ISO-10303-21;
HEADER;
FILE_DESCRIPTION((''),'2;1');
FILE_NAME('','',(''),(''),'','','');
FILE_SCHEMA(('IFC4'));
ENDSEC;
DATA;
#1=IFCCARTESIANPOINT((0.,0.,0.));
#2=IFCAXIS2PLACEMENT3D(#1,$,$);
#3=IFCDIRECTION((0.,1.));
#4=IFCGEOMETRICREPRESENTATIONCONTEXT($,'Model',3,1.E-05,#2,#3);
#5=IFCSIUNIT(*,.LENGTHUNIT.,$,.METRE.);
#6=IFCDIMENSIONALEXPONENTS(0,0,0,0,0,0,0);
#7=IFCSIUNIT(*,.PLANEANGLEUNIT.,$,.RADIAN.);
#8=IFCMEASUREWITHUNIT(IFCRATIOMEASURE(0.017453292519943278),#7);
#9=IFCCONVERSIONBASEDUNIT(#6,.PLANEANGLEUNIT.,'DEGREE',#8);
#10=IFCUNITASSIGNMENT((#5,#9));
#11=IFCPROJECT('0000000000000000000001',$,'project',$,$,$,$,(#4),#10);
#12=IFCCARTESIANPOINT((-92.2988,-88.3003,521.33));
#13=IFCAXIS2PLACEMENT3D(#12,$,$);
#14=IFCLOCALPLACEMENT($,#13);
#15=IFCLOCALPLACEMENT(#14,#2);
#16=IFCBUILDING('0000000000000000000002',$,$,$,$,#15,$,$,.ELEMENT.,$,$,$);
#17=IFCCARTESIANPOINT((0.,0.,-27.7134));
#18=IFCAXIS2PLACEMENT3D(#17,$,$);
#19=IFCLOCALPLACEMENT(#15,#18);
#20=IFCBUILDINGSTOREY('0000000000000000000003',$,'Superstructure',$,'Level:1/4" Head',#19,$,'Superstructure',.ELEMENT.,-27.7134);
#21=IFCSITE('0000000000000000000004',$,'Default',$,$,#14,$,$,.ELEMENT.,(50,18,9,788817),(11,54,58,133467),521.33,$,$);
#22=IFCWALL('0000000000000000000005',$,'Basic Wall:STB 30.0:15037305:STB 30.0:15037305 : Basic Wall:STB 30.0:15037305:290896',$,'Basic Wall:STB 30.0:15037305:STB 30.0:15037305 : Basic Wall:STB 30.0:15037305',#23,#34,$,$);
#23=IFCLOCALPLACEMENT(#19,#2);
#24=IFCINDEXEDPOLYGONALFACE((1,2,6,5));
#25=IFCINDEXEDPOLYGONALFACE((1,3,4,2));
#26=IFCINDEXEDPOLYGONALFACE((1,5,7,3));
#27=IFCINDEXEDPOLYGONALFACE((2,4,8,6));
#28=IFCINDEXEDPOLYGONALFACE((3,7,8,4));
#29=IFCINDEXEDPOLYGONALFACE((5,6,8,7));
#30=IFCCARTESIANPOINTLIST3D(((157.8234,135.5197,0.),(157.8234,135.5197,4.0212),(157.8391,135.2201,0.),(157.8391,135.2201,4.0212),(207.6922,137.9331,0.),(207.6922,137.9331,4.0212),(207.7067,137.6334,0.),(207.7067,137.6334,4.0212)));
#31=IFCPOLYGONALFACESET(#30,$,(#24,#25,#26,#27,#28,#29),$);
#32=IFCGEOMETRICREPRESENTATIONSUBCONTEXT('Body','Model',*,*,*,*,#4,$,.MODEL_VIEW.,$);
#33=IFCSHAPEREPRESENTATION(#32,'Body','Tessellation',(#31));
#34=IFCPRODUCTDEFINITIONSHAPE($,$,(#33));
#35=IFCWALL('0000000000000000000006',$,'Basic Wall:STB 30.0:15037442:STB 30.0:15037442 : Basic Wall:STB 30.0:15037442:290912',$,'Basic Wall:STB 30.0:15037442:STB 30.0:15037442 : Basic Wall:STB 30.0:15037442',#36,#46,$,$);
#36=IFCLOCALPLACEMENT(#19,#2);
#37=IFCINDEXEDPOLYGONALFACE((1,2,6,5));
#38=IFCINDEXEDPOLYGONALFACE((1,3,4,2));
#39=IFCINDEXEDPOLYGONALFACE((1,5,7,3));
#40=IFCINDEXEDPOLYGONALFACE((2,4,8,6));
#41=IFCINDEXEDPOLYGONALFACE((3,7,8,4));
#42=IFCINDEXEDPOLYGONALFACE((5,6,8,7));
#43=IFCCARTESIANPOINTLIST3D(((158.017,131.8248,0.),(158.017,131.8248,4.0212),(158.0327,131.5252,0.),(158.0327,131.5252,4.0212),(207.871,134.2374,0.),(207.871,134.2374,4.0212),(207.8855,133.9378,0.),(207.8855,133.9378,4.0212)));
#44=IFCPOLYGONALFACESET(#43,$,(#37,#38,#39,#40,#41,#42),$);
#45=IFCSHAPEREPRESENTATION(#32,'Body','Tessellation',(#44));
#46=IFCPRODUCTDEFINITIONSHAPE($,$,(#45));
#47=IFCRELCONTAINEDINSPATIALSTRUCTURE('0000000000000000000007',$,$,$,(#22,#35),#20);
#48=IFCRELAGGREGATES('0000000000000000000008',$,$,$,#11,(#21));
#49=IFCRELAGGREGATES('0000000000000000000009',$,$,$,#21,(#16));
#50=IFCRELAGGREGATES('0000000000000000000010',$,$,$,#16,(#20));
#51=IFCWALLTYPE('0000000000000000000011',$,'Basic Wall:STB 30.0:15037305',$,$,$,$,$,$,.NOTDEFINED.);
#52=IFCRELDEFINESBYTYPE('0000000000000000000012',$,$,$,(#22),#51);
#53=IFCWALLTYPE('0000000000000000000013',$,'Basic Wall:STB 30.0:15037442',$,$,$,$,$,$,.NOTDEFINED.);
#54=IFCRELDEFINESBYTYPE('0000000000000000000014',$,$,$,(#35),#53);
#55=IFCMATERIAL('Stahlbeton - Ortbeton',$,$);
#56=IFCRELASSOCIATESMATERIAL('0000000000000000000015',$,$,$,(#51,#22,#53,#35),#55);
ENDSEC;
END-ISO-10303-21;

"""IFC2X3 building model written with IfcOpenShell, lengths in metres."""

from ifc_helpers import new_model, entity, si_unit, converted_unit, direction, frame, origin, place, context, subcontext, project, spatial, polyline, outline, extrude, material, type_object, element, save


model = new_model("IFC2X3")

# Units and contexts
model_context = context("Model", 3, precision=1e-05, world=origin(), true_north=direction((0.0, 1.0)))
body_context = subcontext(model_context, "Body", "Model", "MODEL_VIEW")
ifc_project = project(units=[si_unit("LENGTHUNIT", "METRE"), converted_unit("PLANEANGLEUNIT", "DEGREE", entity("IfcRatioMeasure", 0.017453292519943278), si_unit("PLANEANGLEUNIT", "RADIAN"), dimensions=[0, 0, 0, 0, 0, 0, 0])], contexts=[model_context])

# Site, building, storey
site_placement = place(None, frame((-92.2988, -88.3003, 521.33)))
site = spatial("IfcSite", under=ifc_project, at=site_placement, Name="Default", CompositionType="ELEMENT", RefLatitude=(50, 18, 9, 788817), RefLongitude=(11, 54, 58, 133467), RefElevation=521.33)
building_placement = place(site_placement, origin())
building = spatial("IfcBuilding", under=site, at=building_placement, CompositionType="ELEMENT")
storey_placement = place(building_placement, frame((0.0, 0.0, -27.7134)))
storey = spatial("IfcBuildingStorey", under=building, at=storey_placement, Name="Superstructure", ObjectType="Level:1/4\" Head", LongName="Superstructure", CompositionType="ELEMENT", Elevation=-27.7134)

# Walls
ifc_material_1 = material(Name="Stahlbeton - Ortbeton")
wall_type_1 = type_object("IfcWallType", Name="Basic Wall:STB 30.0:15037305", PredefinedType="NOTDEFINED", material=ifc_material_1)
wall_1_placement = place(storey_placement, frame((157.8234, 135.2201, 0.0)))
element("IfcWall", 1, at=wall_1_placement, inside=storey, type_object=wall_type_1, material=ifc_material_1, Name="Basic Wall:STB 30.0:15037305:STB 30.0:15037305 : Basic Wall:STB 30.0:15037305:290896", ObjectType="Basic Wall:STB 30.0:15037305:STB 30.0:15037305 : Basic Wall:STB 30.0:15037305", context=body_context, shape_type="SweptSolid", body=[
    extrude(outline(polyline([(-24.9633, -0.15), (24.9639, -0.15), (24.9627, 0.15), (-24.9633, 0.15), (-24.9633, -0.15)])), frame((24.942, 1.3565, 0.0), z_axis=(0.0, 0.0, 1.0), x_axis=(-0.998831, -0.048337, 0.0)), (0.0, 0.0, 1.0), 4.0212),
])
wall_type_2 = type_object("IfcWallType", Name="Basic Wall:STB 30.0:15037442", PredefinedType="NOTDEFINED", material=ifc_material_1)
wall_2_placement = place(storey_placement, frame((158.017, 131.5252, 0.0)))
element("IfcWall", 2, at=wall_2_placement, inside=storey, type_object=wall_type_2, material=ifc_material_1, Name="Basic Wall:STB 30.0:15037442:STB 30.0:15037442 : Basic Wall:STB 30.0:15037442:290912", ObjectType="Basic Wall:STB 30.0:15037442:STB 30.0:15037442 : Basic Wall:STB 30.0:15037442", context=body_context, shape_type="SweptSolid", body=[
    extrude(outline(polyline([(-24.9559, -0.15), (24.9565, -0.15), (24.9553, 0.15), (-24.9559, 0.15), (-24.9559, -0.15)])), frame((24.9346, 1.3561, 0.0), z_axis=(0.0, 0.0, 1.0), x_axis=(-0.998831, -0.048337, 0.0)), (0.0, 0.0, 1.0), 4.0212),
])

save(model, "model.ifc")
